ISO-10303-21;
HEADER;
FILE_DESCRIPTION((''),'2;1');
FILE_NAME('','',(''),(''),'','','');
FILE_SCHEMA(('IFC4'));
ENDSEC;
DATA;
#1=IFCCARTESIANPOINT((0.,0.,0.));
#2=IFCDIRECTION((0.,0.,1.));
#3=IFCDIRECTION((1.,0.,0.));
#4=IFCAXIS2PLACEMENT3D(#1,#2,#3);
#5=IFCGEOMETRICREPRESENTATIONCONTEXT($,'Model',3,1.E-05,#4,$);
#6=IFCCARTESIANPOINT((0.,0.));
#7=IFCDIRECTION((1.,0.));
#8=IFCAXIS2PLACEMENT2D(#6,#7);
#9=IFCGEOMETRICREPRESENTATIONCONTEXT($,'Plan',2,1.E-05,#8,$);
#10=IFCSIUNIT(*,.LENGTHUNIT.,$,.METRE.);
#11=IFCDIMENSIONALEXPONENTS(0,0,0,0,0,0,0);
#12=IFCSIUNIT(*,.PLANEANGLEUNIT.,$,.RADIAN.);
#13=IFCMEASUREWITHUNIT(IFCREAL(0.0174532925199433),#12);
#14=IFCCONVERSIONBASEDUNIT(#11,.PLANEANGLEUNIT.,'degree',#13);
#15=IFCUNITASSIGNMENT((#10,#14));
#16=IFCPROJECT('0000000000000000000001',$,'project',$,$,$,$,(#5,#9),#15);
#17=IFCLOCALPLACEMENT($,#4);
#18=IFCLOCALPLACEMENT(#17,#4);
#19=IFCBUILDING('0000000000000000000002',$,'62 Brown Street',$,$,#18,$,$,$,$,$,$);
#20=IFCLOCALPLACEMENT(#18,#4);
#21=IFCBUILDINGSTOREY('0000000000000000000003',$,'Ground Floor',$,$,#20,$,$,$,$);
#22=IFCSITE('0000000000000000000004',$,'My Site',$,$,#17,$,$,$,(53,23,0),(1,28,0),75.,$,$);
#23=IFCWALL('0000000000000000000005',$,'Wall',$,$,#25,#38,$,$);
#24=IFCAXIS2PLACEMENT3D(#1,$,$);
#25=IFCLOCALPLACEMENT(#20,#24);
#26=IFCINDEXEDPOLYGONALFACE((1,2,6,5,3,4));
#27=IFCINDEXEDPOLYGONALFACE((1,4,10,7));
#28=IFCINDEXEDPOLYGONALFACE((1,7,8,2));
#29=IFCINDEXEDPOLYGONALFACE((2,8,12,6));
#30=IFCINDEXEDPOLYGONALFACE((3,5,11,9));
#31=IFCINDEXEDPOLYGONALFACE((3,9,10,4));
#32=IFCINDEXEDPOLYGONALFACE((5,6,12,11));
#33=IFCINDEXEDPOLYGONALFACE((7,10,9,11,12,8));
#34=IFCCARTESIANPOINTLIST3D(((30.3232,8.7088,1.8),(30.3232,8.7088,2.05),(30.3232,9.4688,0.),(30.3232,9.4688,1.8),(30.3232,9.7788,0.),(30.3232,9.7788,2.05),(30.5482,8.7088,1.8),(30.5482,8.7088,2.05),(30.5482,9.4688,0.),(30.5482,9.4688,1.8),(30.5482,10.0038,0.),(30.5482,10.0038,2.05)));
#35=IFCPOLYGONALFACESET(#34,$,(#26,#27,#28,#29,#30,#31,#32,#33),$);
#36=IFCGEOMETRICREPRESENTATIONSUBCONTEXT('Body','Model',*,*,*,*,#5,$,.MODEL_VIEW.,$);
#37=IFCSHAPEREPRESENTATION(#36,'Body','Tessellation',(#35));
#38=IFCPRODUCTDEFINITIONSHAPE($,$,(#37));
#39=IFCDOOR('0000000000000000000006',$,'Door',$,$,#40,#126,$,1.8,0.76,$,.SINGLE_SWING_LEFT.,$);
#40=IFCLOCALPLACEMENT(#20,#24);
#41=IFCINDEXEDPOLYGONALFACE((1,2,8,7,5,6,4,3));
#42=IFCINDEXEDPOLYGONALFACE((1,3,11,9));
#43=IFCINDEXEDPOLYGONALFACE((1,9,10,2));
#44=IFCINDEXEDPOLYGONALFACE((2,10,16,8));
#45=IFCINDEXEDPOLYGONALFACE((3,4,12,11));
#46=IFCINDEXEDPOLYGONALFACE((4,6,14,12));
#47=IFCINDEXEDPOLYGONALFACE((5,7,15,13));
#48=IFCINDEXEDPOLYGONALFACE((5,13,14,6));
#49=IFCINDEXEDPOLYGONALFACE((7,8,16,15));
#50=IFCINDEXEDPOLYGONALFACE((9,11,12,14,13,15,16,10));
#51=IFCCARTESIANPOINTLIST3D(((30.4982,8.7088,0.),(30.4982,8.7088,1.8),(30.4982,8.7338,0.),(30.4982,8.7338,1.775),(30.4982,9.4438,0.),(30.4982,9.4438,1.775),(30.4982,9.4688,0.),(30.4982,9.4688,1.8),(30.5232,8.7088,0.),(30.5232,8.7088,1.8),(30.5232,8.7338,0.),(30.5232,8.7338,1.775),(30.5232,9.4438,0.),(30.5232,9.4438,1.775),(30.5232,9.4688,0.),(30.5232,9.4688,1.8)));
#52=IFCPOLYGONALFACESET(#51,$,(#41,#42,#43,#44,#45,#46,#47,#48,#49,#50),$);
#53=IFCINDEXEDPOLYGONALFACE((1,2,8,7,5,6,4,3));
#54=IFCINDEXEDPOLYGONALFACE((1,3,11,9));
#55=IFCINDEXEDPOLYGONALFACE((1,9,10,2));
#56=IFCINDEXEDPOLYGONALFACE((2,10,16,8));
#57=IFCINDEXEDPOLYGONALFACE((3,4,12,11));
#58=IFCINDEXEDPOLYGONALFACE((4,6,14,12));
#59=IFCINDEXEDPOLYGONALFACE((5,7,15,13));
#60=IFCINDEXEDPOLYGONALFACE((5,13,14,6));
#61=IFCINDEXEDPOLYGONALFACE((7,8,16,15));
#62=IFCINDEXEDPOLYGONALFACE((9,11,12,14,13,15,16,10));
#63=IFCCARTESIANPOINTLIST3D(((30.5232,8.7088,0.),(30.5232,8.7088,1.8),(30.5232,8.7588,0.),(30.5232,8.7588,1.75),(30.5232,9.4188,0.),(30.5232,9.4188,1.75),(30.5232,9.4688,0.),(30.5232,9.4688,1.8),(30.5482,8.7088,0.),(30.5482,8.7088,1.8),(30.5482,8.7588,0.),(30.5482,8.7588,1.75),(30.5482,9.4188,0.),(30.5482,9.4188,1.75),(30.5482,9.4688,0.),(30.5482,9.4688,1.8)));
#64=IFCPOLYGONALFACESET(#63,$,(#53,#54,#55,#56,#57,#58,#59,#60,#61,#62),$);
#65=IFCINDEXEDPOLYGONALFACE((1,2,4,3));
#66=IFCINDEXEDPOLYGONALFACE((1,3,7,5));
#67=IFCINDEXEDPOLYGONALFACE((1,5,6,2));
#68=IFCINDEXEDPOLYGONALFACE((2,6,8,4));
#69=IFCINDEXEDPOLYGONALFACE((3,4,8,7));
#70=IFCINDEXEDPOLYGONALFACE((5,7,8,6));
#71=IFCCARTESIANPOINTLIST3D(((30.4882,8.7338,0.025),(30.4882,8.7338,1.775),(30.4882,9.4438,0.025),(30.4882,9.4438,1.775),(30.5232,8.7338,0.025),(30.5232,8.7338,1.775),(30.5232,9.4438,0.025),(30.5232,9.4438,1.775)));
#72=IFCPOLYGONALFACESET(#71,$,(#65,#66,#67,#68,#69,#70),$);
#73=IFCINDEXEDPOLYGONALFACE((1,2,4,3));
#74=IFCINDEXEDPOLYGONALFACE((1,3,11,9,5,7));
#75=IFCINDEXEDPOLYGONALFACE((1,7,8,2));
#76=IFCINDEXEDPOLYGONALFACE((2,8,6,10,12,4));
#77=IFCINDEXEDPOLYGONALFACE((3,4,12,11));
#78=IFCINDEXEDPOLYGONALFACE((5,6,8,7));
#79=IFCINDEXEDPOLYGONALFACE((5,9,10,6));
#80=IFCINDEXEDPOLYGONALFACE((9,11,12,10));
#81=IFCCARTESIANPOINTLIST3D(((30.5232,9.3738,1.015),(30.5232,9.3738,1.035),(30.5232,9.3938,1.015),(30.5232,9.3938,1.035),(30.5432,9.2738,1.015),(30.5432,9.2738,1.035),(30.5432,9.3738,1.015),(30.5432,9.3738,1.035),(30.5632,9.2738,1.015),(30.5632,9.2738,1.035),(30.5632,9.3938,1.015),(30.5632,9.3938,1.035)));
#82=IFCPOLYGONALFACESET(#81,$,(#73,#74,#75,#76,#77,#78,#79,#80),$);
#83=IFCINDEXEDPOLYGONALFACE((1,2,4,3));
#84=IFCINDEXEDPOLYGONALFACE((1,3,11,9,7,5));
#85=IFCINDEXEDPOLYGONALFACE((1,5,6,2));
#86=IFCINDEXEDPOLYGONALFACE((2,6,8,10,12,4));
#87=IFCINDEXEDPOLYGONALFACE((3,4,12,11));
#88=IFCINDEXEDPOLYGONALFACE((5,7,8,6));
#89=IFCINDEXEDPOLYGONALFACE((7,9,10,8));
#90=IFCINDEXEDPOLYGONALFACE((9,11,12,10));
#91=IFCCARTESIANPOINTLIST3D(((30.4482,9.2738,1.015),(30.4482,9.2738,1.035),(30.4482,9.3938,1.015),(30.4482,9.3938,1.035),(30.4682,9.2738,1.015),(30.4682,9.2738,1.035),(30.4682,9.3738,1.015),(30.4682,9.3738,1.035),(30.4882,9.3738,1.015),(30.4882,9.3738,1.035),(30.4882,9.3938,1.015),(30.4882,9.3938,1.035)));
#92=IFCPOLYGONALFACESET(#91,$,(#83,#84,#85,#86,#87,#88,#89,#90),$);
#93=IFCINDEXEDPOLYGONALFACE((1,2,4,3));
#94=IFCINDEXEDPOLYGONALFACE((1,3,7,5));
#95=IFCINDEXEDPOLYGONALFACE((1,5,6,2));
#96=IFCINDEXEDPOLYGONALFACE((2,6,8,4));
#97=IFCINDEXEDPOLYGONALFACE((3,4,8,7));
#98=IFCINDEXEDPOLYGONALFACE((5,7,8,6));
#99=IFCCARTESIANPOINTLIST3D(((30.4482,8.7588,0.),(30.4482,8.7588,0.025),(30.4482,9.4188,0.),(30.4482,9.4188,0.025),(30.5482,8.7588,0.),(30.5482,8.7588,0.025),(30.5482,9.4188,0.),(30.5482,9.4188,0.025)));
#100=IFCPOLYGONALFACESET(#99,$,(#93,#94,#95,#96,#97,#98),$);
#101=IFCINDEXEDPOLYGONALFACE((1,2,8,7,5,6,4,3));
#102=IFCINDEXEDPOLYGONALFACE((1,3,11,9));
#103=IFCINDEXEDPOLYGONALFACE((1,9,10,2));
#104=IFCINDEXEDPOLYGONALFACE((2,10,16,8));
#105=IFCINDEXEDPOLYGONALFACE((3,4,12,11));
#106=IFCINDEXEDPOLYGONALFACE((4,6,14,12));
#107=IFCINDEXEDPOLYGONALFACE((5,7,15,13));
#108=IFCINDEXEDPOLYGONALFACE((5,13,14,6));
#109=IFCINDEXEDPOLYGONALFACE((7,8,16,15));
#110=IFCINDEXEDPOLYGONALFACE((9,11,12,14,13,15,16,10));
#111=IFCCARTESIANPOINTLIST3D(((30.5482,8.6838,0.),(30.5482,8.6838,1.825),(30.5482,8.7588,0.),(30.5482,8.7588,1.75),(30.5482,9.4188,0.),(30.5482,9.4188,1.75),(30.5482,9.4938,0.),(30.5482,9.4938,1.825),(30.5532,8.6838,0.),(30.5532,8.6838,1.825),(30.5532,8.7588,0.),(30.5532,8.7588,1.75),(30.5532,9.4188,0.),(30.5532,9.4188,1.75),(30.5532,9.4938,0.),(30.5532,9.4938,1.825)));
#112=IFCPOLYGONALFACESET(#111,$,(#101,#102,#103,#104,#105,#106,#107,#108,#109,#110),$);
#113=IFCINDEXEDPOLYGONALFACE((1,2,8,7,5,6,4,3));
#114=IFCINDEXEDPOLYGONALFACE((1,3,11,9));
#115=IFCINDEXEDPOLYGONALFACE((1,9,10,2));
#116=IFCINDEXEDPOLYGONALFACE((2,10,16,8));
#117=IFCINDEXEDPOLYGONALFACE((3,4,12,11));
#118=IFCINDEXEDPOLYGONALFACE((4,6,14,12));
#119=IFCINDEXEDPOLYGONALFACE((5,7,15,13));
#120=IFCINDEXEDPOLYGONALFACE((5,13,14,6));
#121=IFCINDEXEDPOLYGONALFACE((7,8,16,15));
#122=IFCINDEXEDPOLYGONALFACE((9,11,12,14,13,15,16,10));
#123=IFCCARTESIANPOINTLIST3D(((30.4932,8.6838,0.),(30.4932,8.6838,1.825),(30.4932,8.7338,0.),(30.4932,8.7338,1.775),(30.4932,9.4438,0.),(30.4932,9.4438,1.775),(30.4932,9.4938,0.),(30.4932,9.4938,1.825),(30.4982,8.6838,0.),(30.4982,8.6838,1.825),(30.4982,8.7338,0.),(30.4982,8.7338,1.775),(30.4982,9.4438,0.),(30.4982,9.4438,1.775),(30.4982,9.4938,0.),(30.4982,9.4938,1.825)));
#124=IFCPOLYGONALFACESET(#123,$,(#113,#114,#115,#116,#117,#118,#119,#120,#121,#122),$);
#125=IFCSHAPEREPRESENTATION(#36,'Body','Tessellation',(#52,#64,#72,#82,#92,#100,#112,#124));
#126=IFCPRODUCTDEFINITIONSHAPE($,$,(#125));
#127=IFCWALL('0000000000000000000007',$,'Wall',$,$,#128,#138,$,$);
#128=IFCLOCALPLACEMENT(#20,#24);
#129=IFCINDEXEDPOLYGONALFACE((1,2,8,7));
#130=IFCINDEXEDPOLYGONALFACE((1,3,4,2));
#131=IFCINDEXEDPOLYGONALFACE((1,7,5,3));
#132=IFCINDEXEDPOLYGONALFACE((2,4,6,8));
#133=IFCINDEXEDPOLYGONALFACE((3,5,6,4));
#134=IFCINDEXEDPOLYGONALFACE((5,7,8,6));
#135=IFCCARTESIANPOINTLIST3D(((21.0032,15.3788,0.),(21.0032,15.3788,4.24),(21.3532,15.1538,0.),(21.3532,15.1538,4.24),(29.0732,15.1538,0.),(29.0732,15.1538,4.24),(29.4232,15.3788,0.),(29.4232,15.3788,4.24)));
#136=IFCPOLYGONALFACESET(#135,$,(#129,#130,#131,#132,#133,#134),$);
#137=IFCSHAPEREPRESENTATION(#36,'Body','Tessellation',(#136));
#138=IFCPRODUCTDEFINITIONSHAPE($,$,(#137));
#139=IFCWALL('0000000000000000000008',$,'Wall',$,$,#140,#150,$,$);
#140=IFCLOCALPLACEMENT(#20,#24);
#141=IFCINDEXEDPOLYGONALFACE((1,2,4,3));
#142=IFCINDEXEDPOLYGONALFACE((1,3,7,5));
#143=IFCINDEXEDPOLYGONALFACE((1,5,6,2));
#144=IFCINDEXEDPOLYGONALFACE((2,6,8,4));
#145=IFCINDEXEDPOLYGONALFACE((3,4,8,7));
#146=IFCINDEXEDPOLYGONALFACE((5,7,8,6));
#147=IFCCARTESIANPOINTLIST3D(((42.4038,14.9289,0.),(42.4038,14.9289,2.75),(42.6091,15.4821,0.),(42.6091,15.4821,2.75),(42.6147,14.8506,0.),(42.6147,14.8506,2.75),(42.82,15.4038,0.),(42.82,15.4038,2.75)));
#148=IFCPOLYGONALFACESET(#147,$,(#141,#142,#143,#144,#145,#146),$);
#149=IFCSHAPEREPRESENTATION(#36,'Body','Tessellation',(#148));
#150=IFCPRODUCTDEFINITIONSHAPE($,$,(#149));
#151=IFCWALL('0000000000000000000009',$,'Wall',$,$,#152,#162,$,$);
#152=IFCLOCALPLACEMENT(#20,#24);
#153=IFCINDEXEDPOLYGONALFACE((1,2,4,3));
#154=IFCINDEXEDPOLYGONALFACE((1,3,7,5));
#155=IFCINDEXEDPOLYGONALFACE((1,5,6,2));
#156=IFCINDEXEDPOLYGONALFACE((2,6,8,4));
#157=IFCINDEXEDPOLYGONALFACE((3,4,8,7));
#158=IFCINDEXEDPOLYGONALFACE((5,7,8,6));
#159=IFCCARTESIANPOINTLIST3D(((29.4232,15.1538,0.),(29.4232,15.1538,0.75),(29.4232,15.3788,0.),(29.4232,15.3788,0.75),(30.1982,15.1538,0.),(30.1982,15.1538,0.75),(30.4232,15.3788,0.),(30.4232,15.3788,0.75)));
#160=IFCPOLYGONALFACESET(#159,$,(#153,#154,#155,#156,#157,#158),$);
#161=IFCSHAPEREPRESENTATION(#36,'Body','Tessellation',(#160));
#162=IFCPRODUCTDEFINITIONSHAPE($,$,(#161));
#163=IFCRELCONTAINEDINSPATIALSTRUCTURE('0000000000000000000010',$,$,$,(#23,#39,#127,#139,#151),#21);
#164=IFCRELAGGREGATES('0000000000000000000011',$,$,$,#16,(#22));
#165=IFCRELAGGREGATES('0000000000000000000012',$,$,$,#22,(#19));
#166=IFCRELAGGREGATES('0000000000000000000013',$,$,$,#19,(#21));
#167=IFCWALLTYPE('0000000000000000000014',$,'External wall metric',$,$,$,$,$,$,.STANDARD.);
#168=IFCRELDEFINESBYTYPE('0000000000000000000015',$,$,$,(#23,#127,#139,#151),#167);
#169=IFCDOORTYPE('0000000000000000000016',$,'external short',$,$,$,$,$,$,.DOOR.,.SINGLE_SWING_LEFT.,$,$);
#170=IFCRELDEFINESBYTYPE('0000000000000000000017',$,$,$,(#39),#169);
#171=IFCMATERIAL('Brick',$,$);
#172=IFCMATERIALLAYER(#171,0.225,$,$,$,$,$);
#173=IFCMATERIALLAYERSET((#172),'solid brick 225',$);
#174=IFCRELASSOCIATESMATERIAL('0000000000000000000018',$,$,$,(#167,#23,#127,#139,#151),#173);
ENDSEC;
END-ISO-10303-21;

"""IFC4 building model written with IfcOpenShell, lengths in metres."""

from ifc_helpers import new_model, entity, si_unit, converted_unit, frame, origin_with_axes, origin_2d_with_axis, place, context, subcontext, project, spatial, line, indexed_curve, outline, extrude, clip, halfspace, shape, source, transform, mapped, material, layer, layer_set, layer_usage, type_object, type_shapes, element, fill, save


model = new_model("IFC4")

# Units and contexts
model_context = context("Model", 3, precision=1e-05, world=origin_with_axes())
plan_context = context("Plan", 2, precision=1e-05, world=origin_2d_with_axis())
body_context_1 = subcontext(model_context, "Body", "Model", "MODEL_VIEW")
body_context_2 = subcontext(plan_context, "Body", "Plan", "PLAN_VIEW")
ifc_project = project(units=[si_unit("LENGTHUNIT", "METRE"), converted_unit("PLANEANGLEUNIT", "degree", entity("IfcReal", 0.0174532925199433), si_unit("PLANEANGLEUNIT", "RADIAN"), dimensions=[0, 0, 0, 0, 0, 0, 0])], contexts=[model_context, plan_context])

# Site, building, storey
site_placement = place(None, origin_with_axes())
site = spatial("IfcSite", under=ifc_project, at=site_placement, Name="My Site", RefLatitude=(53, 23, 0), RefLongitude=(1, 28, 0), RefElevation=75.0)
building_placement = place(site_placement, origin_with_axes())
building = spatial("IfcBuilding", under=site, at=building_placement, Name="62 Brown Street")
storey_placement = place(building_placement, origin_with_axes())
storey = spatial("IfcBuildingStorey", under=building, at=storey_placement, Name="Ground Floor")

# Shared definitions
ifc_material_1 = material(Name="Brick")
ifc_layer_1 = layer(ifc_material_1, 0.225)
ifc_layer_set_1 = layer_set([ifc_layer_1], Name="solid brick 225")
wall_type_1 = type_object("IfcWallType", Name="External wall metric", PredefinedType="STANDARD", material=ifc_layer_set_1)

# Wall, opening, door
ifc_layer_usage_1 = layer_usage(ifc_layer_set_1, "AXIS2", "POSITIVE", 0.0)
wall_1_placement = place(storey_placement, frame((30.5482, 8.7088, 0.0), z_axis=(0.0, 0.0, 1.0), x_axis=(0.0, 1.0, 0.0)))
wall_1 = element("IfcWall", 1, at=wall_1_placement, inside=storey, type_object=wall_type_1, material=ifc_layer_usage_1, Name="Wall", context=body_context_1, shape_type="Clipping", body=[
    clip(extrude(outline(indexed_curve([(0.0, 0.0), (0.0, 0.225), (1.295, 0.225), (1.295, 0.0), (0.0, 0.0)], self_intersect=False)), origin_with_axes(), (0.0, 0.0, 1.0), 2.05), halfspace(frame((1.295, 0.0, 0.0), z_axis=(0.450001, 0.450001, 0.0), x_axis=(-0.225, 0.225, 0.0)), False)),
])
shared_shape_1 = source(origin_with_axes(), body_context_1, "Body", "SweptSolid", [
    extrude(outline(indexed_curve([(0.0, 0.0), (0.76, 0.0), (0.76, 1.8), (0.0, 1.8)], segments=[line(1, 2, 3, 4, 1)])), frame((0.0, -0.1, 0.0), z_axis=(0.0, -1.0, 0.0), x_axis=(1.0, 0.0, 0.0)), (0.0, 0.0, -1.0), 0.425),
])
opening_1_placement = place(wall_1_placement, frame((0.0, 0.0, 0.0), z_axis=(0.0, 0.0, 1.0), x_axis=(1.0, 0.0, 0.0)))
opening_1 = element("IfcOpeningElement", 2, at=opening_1_placement, cuts=wall_1, PredefinedType="OPENING", context=body_context_1, shape_type="MappedRepresentation", body=[
    mapped(shared_shape_1, transform((0.0, 0.0, 0.0), x_axis=(1.0, 0.0, 0.0), y_axis=(0.0, 1.0, 0.0), z_axis=(0.0, 0.0, 1.0), scale=1.0)),
])
door_type_1 = type_object("IfcDoorType", Name="external short", OperationType="SINGLE_SWING_LEFT", PredefinedType="DOOR")
shared_shape_2 = source(origin_with_axes(), body_context_1, "Body", "SweptSolid", [
    extrude(outline(indexed_curve([(0.0, 0.0), (0.0, 1.8), (0.76, 1.8), (0.76, 0.0), (0.735, 0.0), (0.735, 1.775), (0.025, 1.775), (0.025, 0.0)], segments=[line(1, 2, 3, 4, 5, 6, 7, 8, 1)])), frame((0.0, 0.025, 0.0), z_axis=(0.0, -1.0, 0.0), x_axis=(1.0, 0.0, 0.0)), (0.0, 0.0, -1.0), 0.025),
    extrude(outline(indexed_curve([(0.0, 0.0), (0.0, 1.8), (0.76, 1.8), (0.76, 0.0), (0.71, 0.0), (0.71, 1.75), (0.05, 1.75), (0.05, 0.0)], segments=[line(1, 2, 3, 4, 5, 6, 7, 8, 1)])), frame((0.0, 0.0, 0.0), z_axis=(0.0, -1.0, 0.0), x_axis=(1.0, 0.0, 0.0)), (0.0, 0.0, -1.0), 0.025),
    extrude(outline(indexed_curve([(0.0, 0.0), (0.71, 0.0), (0.71, 0.035), (0.0, 0.035)], segments=[line(1, 2, 3, 4, 1)])), frame((0.025, 0.025, 0.025), z_axis=(0.0, 0.0, 1.0), x_axis=(1.0, 0.0, 0.0)), (0.0, 0.0, 1.0), 1.75),
    extrude(outline(indexed_curve([(0.0, 0.0), (0.0, -0.04), (-0.12, -0.04), (-0.12, -0.02), (-0.02, -0.02), (-0.02, 0.0)], segments=[line(1, 2, 3, 4, 5, 6, 1)])), frame((0.685, 0.025, 1.015), z_axis=(0.0, 0.0, 1.0), x_axis=(1.0, 0.0, 0.0)), (0.0, 0.0, 1.0), 0.02),
    extrude(outline(indexed_curve([(0.0, 0.0), (0.0, 0.04), (-0.12, 0.04), (-0.12, 0.02), (-0.02, 0.02), (-0.02, 0.0)], segments=[line(1, 2, 3, 4, 5, 6, 1)])), frame((0.685, 0.06, 1.015), z_axis=(0.0, 0.0, 1.0), x_axis=(1.0, 0.0, 0.0)), (0.0, 0.0, 1.0), 0.02),
    extrude(outline(indexed_curve([(0.0, 0.0), (0.66, 0.0), (0.66, 0.1), (0.0, 0.1)], segments=[line(1, 2, 3, 4, 1)])), frame((0.05, 0.0, 0.0), z_axis=(0.0, 0.0, 1.0), x_axis=(1.0, 0.0, 0.0)), (0.0, 0.0, 1.0), 0.025),
    extrude(outline(indexed_curve([(0.0, 0.0), (0.0, 1.825), (0.81, 1.825), (0.81, 0.0), (0.735, 0.0), (0.735, 1.75), (0.075, 1.75), (0.075, 0.0)], segments=[line(1, 2, 3, 4, 5, 6, 7, 8, 1)])), frame((-0.025, -0.005, 0.0), z_axis=(0.0, -1.0, 0.0), x_axis=(1.0, 0.0, 0.0)), (0.0, 0.0, -1.0), 0.005),
    extrude(outline(indexed_curve([(0.0, 0.0), (0.0, 1.825), (0.81, 1.825), (0.81, 0.0), (0.76, 0.0), (0.76, 1.775), (0.05, 1.775), (0.05, 0.0)], segments=[line(1, 2, 3, 4, 5, 6, 7, 8, 1)])), frame((-0.025, 0.05, 0.0), z_axis=(0.0, -1.0, 0.0), x_axis=(1.0, 0.0, 0.0)), (0.0, 0.0, -1.0), 0.005),
])
shared_shape_3 = source(origin_with_axes(), body_context_2, "Body", "Curve2D", [
    entity("IfcIndexedPolyCurve", entity("IfcCartesianPointList2D", [[0.0, 0.0], [0.0, 0.05], [0.025, 0.05], [0.025, 0.025], [0.05, 0.025], [0.05, 0.0]]), [entity("IfcLineIndex", [1, 2, 3, 4, 5, 6, 1])]),
    entity("IfcIndexedPolyCurve", entity("IfcCartesianPointList2D", [[0.76, 0.0], [0.76, 0.05], [0.735, 0.05], [0.735, 0.025], [0.71, 0.025], [0.71, 0.0]]), [entity("IfcLineIndex", [1, 2, 3, 4, 5, 6, 1])]),
    entity("IfcTrimmedCurve", entity("IfcEllipse", entity("IfcAxis2Placement2D", entity("IfcCartesianPoint", [0.06, 0.05]), entity("IfcDirection", [1.0, 0.0])), 0.675, 0.71), [entity("IfcCartesianPoint", [0.735, 0.05])], [entity("IfcCartesianPoint", [0.06, 0.76])], True, "CARTESIAN"),
    entity("IfcIndexedPolyCurve", entity("IfcCartesianPointList2D", [[0.025, 0.05], [0.06, 0.05], [0.06, 0.76], [0.025, 0.76]]), [entity("IfcLineIndex", [1, 2, 3, 4, 1])]),
])
type_shapes(door_type_1, [shared_shape_2, shared_shape_3])
door_1_placement = place(opening_1_placement, frame((0.0, 0.0, 0.0), z_axis=(0.0, 0.0, 1.0), x_axis=(1.0, 0.0, 0.0)))
door_1 = element("IfcDoor", 3, at=door_1_placement, inside=storey, type_object=door_type_1, Name="Door", OperationType="SINGLE_SWING_LEFT", OverallHeight=1.8, OverallWidth=0.76, shapes=[
    shape(body_context_1, "Body", "MappedRepresentation", [mapped(shared_shape_2, transform((0.0, 0.0, 0.0), x_axis=(1.0, 0.0, 0.0), y_axis=(0.0, 1.0, 0.0), z_axis=(0.0, 0.0, 1.0), scale=1.0))]),
    shape(body_context_2, "Body", "MappedRepresentation", [mapped(shared_shape_3, transform((0.0, 0.0, 0.0), x_axis=(1.0, 0.0, 0.0), y_axis=(0.0, 1.0, 0.0), z_axis=(0.0, 0.0, 1.0), scale=1.0))]),
])
fill(opening_1, door_1)

# Walls
ifc_layer_usage_2 = layer_usage(ifc_layer_set_1, "AXIS2", "POSITIVE", 0.0)
wall_2_placement = place(storey_placement, frame((29.4232, 15.3788, 0.0), z_axis=(0.0, 0.0, 1.0), x_axis=(-1.0, 0.0, 0.0)))
element("IfcWall", 4, at=wall_2_placement, inside=storey, type_object=wall_type_1, material=ifc_layer_usage_2, Name="Wall", context=body_context_1, shape_type="Clipping", body=[
    clip(clip(extrude(outline(indexed_curve([(0.0, 0.0), (0.0, 0.225), (8.42, 0.225), (8.42, 0.0), (0.0, 0.0)], self_intersect=False)), origin_with_axes(), (0.0, 0.0, 1.0), 4.24), halfspace(frame((8.42, 0.0, 0.0), z_axis=(0.540756, 0.841179, 0.0), x_axis=(-0.841179, 0.540756, 0.0)), False)), halfspace(frame((0.0, 0.0, 0.0), z_axis=(-0.540758, 0.841178, 0.0), x_axis=(0.841178, 0.540758, 0.0)), False)),
])
ifc_layer_usage_3 = layer_usage(ifc_layer_set_1, "AXIS2", "POSITIVE", 0.0)
wall_3_placement = place(storey_placement, frame((42.6147, 14.8506, 0.0), z_axis=(0.0, 0.0, 1.0), x_axis=(0.347944, 0.937515, 0.0)))
element("IfcWall", 5, at=wall_3_placement, inside=storey, type_object=wall_type_1, material=ifc_layer_usage_3, Name="Wall", context=body_context_1, shape_type="SweptSolid", body=[
    extrude(outline(indexed_curve([(0.0, 0.0), (0.0, 0.225), (0.5901, 0.225), (0.5901, 0.0), (0.0, 0.0)], self_intersect=False)), origin_with_axes(), (0.0, 0.0, 1.0), 2.75),
])
ifc_layer_usage_4 = layer_usage(ifc_layer_set_1, "AXIS2", "POSITIVE", 0.0)
wall_4_placement = place(storey_placement, frame((30.4232, 15.3788, 0.0), z_axis=(0.0, 0.0, 1.0), x_axis=(-1.0, 0.0, 0.0)))
element("IfcWall", 6, at=wall_4_placement, inside=storey, type_object=wall_type_1, material=ifc_layer_usage_4, Name="Wall", context=body_context_1, shape_type="Clipping", body=[
    clip(extrude(outline(indexed_curve([(0.0, 0.0), (0.0, 0.225), (1.0, 0.225), (1.0, 0.0), (0.0, 0.0)], self_intersect=False)), origin_with_axes(), (0.0, 0.0, 1.0), 0.75), halfspace(frame((0.0, 0.0, 0.0), z_axis=(-0.707107, 0.707107, 0.0), x_axis=(0.707107, 0.707107, 0.0)), False)),
])

save(model, "model.ifc")
